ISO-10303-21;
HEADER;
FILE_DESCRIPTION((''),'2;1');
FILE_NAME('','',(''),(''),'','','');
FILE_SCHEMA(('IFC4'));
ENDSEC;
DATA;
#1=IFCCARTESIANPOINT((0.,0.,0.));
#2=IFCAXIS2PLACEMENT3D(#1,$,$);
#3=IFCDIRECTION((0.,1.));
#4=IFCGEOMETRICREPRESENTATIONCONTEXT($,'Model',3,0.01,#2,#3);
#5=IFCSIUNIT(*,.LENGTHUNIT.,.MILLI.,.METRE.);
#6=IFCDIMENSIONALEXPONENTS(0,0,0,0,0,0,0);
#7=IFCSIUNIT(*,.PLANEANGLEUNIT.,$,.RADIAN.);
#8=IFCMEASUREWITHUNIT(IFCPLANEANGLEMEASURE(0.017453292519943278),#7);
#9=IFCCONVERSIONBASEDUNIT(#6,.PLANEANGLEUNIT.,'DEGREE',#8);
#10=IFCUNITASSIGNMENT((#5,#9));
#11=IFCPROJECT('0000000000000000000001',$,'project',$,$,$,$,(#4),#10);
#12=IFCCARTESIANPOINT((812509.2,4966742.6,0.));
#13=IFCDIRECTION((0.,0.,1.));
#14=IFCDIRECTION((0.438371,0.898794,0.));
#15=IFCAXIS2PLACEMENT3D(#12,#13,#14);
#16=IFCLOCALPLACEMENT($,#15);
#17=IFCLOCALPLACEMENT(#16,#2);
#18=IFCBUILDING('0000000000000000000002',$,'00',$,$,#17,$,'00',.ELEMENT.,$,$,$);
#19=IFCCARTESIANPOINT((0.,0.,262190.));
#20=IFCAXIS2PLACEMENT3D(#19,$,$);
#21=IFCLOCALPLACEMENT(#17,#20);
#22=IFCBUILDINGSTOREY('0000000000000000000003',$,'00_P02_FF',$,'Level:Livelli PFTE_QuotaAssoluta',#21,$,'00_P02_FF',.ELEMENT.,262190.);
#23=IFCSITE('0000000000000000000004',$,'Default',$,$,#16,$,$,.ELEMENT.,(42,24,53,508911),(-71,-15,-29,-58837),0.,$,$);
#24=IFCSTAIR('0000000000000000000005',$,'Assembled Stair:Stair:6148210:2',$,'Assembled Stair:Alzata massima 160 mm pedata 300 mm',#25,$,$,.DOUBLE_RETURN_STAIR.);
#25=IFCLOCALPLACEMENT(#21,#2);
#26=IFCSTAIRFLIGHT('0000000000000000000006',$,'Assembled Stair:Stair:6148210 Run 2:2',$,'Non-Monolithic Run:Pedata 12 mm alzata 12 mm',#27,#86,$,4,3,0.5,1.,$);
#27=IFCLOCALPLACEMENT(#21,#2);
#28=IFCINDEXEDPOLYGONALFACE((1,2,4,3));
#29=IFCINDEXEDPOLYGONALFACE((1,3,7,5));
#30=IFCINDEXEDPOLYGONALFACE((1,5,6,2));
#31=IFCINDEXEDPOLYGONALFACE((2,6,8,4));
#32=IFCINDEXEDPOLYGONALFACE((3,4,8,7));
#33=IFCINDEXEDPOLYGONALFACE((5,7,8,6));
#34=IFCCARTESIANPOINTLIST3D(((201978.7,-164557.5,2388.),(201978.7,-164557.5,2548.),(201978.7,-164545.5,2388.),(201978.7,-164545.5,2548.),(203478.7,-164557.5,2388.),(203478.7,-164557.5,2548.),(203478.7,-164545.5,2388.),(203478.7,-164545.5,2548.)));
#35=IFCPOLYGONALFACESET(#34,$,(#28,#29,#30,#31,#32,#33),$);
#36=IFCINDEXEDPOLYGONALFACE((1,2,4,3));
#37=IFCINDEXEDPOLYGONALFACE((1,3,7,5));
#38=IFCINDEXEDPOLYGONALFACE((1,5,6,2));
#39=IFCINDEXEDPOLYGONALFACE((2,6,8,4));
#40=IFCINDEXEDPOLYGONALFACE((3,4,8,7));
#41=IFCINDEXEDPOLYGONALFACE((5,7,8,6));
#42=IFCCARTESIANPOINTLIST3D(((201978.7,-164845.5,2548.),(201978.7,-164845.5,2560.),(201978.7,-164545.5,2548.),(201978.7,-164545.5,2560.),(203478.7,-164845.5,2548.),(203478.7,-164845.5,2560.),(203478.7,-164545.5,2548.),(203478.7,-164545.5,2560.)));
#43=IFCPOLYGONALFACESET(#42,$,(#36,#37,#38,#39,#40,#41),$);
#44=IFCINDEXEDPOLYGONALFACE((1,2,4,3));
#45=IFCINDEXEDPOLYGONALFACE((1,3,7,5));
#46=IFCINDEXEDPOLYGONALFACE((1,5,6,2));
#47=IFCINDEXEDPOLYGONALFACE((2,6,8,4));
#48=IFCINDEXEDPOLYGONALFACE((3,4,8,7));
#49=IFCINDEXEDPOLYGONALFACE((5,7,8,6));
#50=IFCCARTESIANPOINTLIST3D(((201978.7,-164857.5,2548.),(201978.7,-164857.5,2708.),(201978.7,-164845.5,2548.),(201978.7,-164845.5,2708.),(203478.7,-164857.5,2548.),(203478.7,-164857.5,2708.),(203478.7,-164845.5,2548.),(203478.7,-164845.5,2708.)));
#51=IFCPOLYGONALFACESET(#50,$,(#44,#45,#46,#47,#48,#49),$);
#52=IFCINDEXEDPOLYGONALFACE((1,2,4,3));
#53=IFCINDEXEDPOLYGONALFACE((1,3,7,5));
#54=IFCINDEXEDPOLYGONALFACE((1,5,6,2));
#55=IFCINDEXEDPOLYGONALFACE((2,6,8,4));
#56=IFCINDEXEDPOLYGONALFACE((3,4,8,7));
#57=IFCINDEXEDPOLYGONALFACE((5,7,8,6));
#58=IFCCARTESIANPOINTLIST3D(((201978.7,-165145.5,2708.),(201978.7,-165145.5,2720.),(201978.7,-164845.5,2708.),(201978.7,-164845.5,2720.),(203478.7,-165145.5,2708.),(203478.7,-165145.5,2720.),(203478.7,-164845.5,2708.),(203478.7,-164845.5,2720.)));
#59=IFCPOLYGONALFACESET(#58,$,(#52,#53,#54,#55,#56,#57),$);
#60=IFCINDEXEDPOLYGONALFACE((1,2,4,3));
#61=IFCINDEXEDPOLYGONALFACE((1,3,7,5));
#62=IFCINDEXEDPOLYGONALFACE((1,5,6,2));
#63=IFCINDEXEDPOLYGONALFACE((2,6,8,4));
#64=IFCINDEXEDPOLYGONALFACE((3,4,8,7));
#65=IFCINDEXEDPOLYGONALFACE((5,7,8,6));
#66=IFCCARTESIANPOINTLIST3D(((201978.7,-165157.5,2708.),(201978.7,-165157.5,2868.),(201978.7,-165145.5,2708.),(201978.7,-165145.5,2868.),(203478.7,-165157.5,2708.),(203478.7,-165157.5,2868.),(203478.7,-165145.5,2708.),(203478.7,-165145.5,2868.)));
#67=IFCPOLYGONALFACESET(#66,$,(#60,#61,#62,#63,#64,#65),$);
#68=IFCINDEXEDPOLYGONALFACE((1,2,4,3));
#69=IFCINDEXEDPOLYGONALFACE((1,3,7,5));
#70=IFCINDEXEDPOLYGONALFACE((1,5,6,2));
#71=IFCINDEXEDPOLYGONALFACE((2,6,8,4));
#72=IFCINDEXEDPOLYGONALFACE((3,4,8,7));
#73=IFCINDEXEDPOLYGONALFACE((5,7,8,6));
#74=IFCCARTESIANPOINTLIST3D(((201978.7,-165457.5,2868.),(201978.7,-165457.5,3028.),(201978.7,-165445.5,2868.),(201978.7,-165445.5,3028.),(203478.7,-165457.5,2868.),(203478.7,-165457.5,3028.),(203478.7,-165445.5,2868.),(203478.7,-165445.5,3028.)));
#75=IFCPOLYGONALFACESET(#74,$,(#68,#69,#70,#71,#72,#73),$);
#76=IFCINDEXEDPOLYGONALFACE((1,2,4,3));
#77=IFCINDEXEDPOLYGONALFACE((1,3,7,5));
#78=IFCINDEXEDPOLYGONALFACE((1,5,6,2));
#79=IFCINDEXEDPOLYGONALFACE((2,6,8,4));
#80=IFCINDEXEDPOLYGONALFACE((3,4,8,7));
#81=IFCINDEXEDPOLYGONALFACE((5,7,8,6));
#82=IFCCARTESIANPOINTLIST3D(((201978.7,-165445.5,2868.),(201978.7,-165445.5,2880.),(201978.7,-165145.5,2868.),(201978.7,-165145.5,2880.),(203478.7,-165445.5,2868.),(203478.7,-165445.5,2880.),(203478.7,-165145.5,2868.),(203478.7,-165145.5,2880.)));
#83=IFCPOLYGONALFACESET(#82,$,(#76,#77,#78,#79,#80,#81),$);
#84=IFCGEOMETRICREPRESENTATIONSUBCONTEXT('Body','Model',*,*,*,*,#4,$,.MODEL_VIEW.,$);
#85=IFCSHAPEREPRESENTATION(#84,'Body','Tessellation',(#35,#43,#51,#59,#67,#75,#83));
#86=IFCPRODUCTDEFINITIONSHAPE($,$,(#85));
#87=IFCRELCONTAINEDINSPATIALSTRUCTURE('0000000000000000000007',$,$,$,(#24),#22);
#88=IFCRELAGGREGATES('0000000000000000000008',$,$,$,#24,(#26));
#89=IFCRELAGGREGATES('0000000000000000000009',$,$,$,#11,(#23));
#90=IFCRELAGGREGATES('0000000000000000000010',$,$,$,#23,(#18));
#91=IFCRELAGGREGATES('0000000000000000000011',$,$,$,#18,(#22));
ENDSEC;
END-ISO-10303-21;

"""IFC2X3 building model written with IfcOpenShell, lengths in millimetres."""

from ifc_helpers import new_model, entity, si_unit, converted_unit, direction, frame, origin, origin_2d_with_axis, place, context, subcontext, project, spatial, rectangle, extrude, element, aggregate, save


model = new_model("IFC2X3")

# Units and contexts
model_context = context("Model", 3, precision=0.01, world=origin(), true_north=direction((0.0, 1.0)))
body_context = subcontext(model_context, "Body", "Model", "MODEL_VIEW")
ifc_project = project(units=[si_unit("LENGTHUNIT", "METRE", prefix="MILLI"), converted_unit("PLANEANGLEUNIT", "DEGREE", entity("IfcPlaneAngleMeasure", 0.017453292519943278), si_unit("PLANEANGLEUNIT", "RADIAN"), dimensions=[0, 0, 0, 0, 0, 0, 0])], contexts=[model_context])

# Site, building, storey
site_placement = place(None, frame((812509.2, 4966742.6, 0.0), z_axis=(0.0, 0.0, 1.0), x_axis=(0.438371, 0.898794, 0.0)))
site = spatial("IfcSite", under=ifc_project, at=site_placement, Name="Default", CompositionType="ELEMENT", RefLatitude=(42, 24, 53, 508911), RefLongitude=(-71, -15, -29, -58837), RefElevation=0.0)
building_placement = place(site_placement, origin())
building = spatial("IfcBuilding", under=site, at=building_placement, Name="00", LongName="00", CompositionType="ELEMENT")
storey_placement = place(building_placement, frame((0.0, 0.0, 262190.0)))
storey = spatial("IfcBuildingStorey", under=building, at=storey_placement, Name="00_P02_FF", ObjectType="Level:Livelli PFTE_QuotaAssoluta", LongName="00_P02_FF", CompositionType="ELEMENT", Elevation=262190.0)

# Stair
stair_1_placement = place(storey_placement, origin())
stair_1 = element("IfcStair", 1, at=stair_1_placement, inside=storey, Name="Assembled Stair:Stair:6148210:2", ObjectType="Assembled Stair:Alzata massima 160 mm pedata 300 mm", ShapeType="DOUBLE_RETURN_STAIR")

# Stair flight
stair_flight_1_placement = place(stair_1_placement, origin())
stair_flight_1 = element("IfcStairFlight", 2, at=stair_flight_1_placement, Name="Assembled Stair:Stair:6148210 Run 2:2", ObjectType="Non-Monolithic Run:Pedata 12 mm alzata 12 mm", NumberOfRiser=4, NumberOfTreads=3, RiserHeight=0.5, TreadLength=1.0, context=body_context, shape_type="SweptSolid", body=[
    extrude(rectangle(XDim=1500.0, YDim=12.0, at=origin_2d_with_axis()), frame((202728.7, -164551.5, 2388.0)), (0.0, 0.0, 1.0), 160.0),
    extrude(rectangle(XDim=300.0, YDim=1500.0, at=origin_2d_with_axis()), frame((202728.7, -164695.5, 2548.0), z_axis=(0.0, 0.0, 1.0), x_axis=(0.0, 1.0, 0.0)), (0.0, 0.0, 1.0), 12.0),
    extrude(rectangle(XDim=1500.0, YDim=12.0, at=origin_2d_with_axis()), frame((202728.7, -164851.5, 2548.0)), (0.0, 0.0, 1.0), 160.0),
    extrude(rectangle(XDim=300.0, YDim=1500.0, at=origin_2d_with_axis()), frame((202728.7, -164995.5, 2708.0), z_axis=(0.0, 0.0, 1.0), x_axis=(0.0, 1.0, 0.0)), (0.0, 0.0, 1.0), 12.0),
    extrude(rectangle(XDim=1500.0, YDim=12.0, at=origin_2d_with_axis()), frame((202728.7, -165151.5, 2708.0)), (0.0, 0.0, 1.0), 160.0),
    extrude(rectangle(XDim=1500.0, YDim=12.0, at=origin_2d_with_axis()), frame((202728.7, -165451.5, 2868.0)), (0.0, 0.0, 1.0), 160.0),
    extrude(rectangle(XDim=300.0, YDim=1500.0, at=origin_2d_with_axis()), frame((202728.7, -165295.5, 2868.0), z_axis=(0.0, 0.0, 1.0), x_axis=(0.0, 1.0, 0.0)), (0.0, 0.0, 1.0), 12.0),
])
aggregate(stair_1, [stair_flight_1])

save(model, "model.ifc")
